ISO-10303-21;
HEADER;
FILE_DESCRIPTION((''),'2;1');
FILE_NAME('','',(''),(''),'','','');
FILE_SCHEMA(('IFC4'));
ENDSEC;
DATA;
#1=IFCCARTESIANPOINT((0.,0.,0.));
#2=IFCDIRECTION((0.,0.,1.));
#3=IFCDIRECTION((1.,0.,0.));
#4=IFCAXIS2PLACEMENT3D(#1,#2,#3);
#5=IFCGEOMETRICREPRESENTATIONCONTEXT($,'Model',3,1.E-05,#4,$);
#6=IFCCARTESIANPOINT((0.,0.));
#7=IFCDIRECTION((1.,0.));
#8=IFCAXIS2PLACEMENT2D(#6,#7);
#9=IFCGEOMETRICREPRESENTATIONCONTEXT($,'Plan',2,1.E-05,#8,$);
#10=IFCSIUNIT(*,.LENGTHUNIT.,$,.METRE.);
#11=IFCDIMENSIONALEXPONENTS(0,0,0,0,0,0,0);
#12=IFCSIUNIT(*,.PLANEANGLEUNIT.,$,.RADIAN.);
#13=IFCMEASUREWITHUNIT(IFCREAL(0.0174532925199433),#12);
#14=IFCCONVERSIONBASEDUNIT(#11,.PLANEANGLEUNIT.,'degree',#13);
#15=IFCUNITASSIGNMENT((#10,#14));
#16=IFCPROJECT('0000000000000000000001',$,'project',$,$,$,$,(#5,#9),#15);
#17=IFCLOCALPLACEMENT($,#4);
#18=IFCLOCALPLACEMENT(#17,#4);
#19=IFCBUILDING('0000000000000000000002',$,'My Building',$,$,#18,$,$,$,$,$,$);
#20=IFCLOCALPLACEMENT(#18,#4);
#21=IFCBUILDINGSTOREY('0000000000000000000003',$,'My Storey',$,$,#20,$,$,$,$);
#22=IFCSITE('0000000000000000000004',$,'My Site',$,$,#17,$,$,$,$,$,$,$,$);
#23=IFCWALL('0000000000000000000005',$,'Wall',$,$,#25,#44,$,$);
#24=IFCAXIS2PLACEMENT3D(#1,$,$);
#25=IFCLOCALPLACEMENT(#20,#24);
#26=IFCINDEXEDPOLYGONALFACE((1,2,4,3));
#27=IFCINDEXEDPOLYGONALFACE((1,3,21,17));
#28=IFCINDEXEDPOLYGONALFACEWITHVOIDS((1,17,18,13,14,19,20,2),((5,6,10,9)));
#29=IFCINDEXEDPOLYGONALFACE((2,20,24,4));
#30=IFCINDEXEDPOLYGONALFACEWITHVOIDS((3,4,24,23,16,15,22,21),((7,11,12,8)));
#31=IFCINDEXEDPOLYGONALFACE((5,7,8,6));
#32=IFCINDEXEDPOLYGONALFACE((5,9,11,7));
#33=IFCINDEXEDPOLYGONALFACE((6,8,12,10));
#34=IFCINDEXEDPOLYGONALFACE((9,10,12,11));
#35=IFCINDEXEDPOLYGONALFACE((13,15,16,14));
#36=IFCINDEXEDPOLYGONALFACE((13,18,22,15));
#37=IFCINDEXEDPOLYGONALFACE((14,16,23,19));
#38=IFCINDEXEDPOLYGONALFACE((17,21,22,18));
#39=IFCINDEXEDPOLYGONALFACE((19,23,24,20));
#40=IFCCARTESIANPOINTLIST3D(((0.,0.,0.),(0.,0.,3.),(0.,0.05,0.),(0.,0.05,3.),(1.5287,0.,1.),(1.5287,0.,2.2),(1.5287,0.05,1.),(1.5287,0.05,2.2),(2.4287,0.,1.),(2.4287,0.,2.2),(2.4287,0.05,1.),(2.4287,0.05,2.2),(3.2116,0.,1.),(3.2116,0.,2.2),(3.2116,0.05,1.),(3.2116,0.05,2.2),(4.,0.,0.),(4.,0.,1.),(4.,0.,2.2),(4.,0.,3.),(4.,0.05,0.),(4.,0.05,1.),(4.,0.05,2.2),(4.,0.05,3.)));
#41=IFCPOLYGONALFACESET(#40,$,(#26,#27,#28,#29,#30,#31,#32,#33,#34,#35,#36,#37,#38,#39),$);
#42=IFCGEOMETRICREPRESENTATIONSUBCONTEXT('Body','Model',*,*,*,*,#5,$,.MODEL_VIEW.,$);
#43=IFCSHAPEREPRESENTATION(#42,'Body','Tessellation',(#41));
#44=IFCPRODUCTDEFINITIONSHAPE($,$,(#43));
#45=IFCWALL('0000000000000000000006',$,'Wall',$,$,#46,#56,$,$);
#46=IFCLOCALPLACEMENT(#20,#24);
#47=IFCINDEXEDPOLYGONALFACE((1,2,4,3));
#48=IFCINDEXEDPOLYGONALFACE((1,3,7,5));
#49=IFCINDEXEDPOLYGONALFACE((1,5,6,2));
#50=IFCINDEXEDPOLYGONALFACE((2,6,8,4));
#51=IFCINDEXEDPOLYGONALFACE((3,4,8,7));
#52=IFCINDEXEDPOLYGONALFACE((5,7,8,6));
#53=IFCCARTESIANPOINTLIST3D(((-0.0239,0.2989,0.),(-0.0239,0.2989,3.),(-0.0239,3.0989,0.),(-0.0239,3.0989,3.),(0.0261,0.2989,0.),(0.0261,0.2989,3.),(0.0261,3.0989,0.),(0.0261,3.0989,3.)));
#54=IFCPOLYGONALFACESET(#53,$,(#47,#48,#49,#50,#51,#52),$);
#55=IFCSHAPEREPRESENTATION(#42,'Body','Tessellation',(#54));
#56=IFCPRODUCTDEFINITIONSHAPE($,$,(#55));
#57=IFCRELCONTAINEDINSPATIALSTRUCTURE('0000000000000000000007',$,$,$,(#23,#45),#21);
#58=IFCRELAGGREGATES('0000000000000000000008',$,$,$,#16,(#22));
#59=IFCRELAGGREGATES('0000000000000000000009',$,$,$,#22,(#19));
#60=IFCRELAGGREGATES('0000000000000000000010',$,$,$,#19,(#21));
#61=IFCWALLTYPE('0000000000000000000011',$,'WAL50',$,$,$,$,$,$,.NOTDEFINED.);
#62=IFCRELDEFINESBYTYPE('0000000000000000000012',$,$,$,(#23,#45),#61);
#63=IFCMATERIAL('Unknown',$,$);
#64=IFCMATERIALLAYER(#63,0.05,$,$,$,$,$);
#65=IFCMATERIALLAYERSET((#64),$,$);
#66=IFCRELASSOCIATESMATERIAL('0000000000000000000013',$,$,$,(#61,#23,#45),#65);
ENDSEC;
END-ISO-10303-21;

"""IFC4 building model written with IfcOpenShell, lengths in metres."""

from ifc_helpers import new_model, entity, si_unit, converted_unit, frame, origin_with_axes, origin_2d_with_axis, place, context, subcontext, project, spatial, line, indexed_curve, outline, extrude, source, transform, mapped, material, layer, layer_set, layer_usage, type_object, element, save


model = new_model("IFC4")

# Units and contexts
model_context = context("Model", 3, precision=1e-05, world=origin_with_axes())
plan_context = context("Plan", 2, precision=1e-05, world=origin_2d_with_axis())
body_context = subcontext(model_context, "Body", "Model", "MODEL_VIEW")
ifc_project = project(units=[si_unit("LENGTHUNIT", "METRE"), converted_unit("PLANEANGLEUNIT", "degree", entity("IfcReal", 0.0174532925199433), si_unit("PLANEANGLEUNIT", "RADIAN"), dimensions=[0, 0, 0, 0, 0, 0, 0])], contexts=[model_context, plan_context])

# Site, building, storey
site_placement = place(None, origin_with_axes())
site = spatial("IfcSite", under=ifc_project, at=site_placement, Name="My Site")
building_placement = place(site_placement, origin_with_axes())
building = spatial("IfcBuilding", under=site, at=building_placement, Name="My Building")
storey_placement = place(building_placement, origin_with_axes())
storey = spatial("IfcBuildingStorey", under=building, at=storey_placement, Name="My Storey")

# Wall, openings
ifc_material = material(Name="Unknown")
ifc_layer = layer(ifc_material, 0.05)
ifc_layer_set = layer_set([ifc_layer])
ifc_layer_usage_1 = layer_usage(ifc_layer_set, "AXIS2", "POSITIVE", 0.0)
wall_type = type_object("IfcWallType", Name="WAL50", PredefinedType="NOTDEFINED", material=ifc_layer_set)
wall_1_placement = place(storey_placement, origin_with_axes())
wall_1 = element("IfcWall", 1, at=wall_1_placement, inside=storey, type_object=wall_type, material=ifc_layer_usage_1, Name="Wall", context=body_context, shape_type="SweptSolid", body=[
    extrude(outline(indexed_curve([(0.0, 0.0), (0.0, 0.05), (4.0, 0.05), (4.0, 0.0), (0.0, 0.0)], self_intersect=False)), origin_with_axes(), (0.0, 0.0, 1.0), 3.0),
])
shared_shape = source(origin_with_axes(), body_context, "Body", "SweptSolid", [
    extrude(outline(indexed_curve([(0.0, 0.0), (0.9, 0.0), (0.9, 1.2), (0.0, 1.2)], segments=[line(1, 2, 3, 4, 1)])), frame((0.0, -0.6, 0.0), z_axis=(0.0, -1.0, 0.0), x_axis=(1.0, 0.0, 0.0)), (0.0, 0.0, -1.0), 1.2),
])
opening_1_placement = place(wall_1_placement, frame((1.5287, 0.0, 1.0), z_axis=(0.0, 0.0, 1.0), x_axis=(1.0, 0.0, 0.0)))
element("IfcOpeningElement", 2, at=opening_1_placement, cuts=wall_1, PredefinedType="OPENING", context=body_context, shape_type="MappedRepresentation", body=[
    mapped(shared_shape, transform((0.0, 0.0, 0.0), x_axis=(1.0, 0.0, 0.0), y_axis=(0.0, 1.0, 0.0), z_axis=(0.0, 0.0, 1.0), scale=1.0)),
])
opening_2_placement = place(wall_1_placement, frame((3.2116, 0.0, 1.0), z_axis=(0.0, 0.0, 1.0), x_axis=(1.0, 0.0, 0.0)))
element("IfcOpeningElement", 3, at=opening_2_placement, cuts=wall_1, PredefinedType="OPENING", context=body_context, shape_type="MappedRepresentation", body=[
    mapped(shared_shape, transform((0.0, 0.0, 0.0), x_axis=(1.0, 0.0, 0.0), y_axis=(0.0, 1.0, 0.0), z_axis=(0.0, 0.0, 1.0), scale=1.0)),
])

# Wall
ifc_layer_usage_2 = layer_usage(ifc_layer_set, "AXIS2", "POSITIVE", 0.0)
wall_2_placement = place(storey_placement, frame((0.0261, 0.2989, 0.0), z_axis=(0.0, 0.0, 1.0), x_axis=(0.0, 1.0, 0.0)))
element("IfcWall", 4, at=wall_2_placement, inside=storey, type_object=wall_type, material=ifc_layer_usage_2, Name="Wall", context=body_context, shape_type="SweptSolid", body=[
    extrude(outline(indexed_curve([(0.0, 0.0), (0.0, 0.05), (2.8, 0.05), (2.8, 0.0), (0.0, 0.0)], self_intersect=False)), origin_with_axes(), (0.0, 0.0, 1.0), 3.0),
])

save(model, "model.ifc")
